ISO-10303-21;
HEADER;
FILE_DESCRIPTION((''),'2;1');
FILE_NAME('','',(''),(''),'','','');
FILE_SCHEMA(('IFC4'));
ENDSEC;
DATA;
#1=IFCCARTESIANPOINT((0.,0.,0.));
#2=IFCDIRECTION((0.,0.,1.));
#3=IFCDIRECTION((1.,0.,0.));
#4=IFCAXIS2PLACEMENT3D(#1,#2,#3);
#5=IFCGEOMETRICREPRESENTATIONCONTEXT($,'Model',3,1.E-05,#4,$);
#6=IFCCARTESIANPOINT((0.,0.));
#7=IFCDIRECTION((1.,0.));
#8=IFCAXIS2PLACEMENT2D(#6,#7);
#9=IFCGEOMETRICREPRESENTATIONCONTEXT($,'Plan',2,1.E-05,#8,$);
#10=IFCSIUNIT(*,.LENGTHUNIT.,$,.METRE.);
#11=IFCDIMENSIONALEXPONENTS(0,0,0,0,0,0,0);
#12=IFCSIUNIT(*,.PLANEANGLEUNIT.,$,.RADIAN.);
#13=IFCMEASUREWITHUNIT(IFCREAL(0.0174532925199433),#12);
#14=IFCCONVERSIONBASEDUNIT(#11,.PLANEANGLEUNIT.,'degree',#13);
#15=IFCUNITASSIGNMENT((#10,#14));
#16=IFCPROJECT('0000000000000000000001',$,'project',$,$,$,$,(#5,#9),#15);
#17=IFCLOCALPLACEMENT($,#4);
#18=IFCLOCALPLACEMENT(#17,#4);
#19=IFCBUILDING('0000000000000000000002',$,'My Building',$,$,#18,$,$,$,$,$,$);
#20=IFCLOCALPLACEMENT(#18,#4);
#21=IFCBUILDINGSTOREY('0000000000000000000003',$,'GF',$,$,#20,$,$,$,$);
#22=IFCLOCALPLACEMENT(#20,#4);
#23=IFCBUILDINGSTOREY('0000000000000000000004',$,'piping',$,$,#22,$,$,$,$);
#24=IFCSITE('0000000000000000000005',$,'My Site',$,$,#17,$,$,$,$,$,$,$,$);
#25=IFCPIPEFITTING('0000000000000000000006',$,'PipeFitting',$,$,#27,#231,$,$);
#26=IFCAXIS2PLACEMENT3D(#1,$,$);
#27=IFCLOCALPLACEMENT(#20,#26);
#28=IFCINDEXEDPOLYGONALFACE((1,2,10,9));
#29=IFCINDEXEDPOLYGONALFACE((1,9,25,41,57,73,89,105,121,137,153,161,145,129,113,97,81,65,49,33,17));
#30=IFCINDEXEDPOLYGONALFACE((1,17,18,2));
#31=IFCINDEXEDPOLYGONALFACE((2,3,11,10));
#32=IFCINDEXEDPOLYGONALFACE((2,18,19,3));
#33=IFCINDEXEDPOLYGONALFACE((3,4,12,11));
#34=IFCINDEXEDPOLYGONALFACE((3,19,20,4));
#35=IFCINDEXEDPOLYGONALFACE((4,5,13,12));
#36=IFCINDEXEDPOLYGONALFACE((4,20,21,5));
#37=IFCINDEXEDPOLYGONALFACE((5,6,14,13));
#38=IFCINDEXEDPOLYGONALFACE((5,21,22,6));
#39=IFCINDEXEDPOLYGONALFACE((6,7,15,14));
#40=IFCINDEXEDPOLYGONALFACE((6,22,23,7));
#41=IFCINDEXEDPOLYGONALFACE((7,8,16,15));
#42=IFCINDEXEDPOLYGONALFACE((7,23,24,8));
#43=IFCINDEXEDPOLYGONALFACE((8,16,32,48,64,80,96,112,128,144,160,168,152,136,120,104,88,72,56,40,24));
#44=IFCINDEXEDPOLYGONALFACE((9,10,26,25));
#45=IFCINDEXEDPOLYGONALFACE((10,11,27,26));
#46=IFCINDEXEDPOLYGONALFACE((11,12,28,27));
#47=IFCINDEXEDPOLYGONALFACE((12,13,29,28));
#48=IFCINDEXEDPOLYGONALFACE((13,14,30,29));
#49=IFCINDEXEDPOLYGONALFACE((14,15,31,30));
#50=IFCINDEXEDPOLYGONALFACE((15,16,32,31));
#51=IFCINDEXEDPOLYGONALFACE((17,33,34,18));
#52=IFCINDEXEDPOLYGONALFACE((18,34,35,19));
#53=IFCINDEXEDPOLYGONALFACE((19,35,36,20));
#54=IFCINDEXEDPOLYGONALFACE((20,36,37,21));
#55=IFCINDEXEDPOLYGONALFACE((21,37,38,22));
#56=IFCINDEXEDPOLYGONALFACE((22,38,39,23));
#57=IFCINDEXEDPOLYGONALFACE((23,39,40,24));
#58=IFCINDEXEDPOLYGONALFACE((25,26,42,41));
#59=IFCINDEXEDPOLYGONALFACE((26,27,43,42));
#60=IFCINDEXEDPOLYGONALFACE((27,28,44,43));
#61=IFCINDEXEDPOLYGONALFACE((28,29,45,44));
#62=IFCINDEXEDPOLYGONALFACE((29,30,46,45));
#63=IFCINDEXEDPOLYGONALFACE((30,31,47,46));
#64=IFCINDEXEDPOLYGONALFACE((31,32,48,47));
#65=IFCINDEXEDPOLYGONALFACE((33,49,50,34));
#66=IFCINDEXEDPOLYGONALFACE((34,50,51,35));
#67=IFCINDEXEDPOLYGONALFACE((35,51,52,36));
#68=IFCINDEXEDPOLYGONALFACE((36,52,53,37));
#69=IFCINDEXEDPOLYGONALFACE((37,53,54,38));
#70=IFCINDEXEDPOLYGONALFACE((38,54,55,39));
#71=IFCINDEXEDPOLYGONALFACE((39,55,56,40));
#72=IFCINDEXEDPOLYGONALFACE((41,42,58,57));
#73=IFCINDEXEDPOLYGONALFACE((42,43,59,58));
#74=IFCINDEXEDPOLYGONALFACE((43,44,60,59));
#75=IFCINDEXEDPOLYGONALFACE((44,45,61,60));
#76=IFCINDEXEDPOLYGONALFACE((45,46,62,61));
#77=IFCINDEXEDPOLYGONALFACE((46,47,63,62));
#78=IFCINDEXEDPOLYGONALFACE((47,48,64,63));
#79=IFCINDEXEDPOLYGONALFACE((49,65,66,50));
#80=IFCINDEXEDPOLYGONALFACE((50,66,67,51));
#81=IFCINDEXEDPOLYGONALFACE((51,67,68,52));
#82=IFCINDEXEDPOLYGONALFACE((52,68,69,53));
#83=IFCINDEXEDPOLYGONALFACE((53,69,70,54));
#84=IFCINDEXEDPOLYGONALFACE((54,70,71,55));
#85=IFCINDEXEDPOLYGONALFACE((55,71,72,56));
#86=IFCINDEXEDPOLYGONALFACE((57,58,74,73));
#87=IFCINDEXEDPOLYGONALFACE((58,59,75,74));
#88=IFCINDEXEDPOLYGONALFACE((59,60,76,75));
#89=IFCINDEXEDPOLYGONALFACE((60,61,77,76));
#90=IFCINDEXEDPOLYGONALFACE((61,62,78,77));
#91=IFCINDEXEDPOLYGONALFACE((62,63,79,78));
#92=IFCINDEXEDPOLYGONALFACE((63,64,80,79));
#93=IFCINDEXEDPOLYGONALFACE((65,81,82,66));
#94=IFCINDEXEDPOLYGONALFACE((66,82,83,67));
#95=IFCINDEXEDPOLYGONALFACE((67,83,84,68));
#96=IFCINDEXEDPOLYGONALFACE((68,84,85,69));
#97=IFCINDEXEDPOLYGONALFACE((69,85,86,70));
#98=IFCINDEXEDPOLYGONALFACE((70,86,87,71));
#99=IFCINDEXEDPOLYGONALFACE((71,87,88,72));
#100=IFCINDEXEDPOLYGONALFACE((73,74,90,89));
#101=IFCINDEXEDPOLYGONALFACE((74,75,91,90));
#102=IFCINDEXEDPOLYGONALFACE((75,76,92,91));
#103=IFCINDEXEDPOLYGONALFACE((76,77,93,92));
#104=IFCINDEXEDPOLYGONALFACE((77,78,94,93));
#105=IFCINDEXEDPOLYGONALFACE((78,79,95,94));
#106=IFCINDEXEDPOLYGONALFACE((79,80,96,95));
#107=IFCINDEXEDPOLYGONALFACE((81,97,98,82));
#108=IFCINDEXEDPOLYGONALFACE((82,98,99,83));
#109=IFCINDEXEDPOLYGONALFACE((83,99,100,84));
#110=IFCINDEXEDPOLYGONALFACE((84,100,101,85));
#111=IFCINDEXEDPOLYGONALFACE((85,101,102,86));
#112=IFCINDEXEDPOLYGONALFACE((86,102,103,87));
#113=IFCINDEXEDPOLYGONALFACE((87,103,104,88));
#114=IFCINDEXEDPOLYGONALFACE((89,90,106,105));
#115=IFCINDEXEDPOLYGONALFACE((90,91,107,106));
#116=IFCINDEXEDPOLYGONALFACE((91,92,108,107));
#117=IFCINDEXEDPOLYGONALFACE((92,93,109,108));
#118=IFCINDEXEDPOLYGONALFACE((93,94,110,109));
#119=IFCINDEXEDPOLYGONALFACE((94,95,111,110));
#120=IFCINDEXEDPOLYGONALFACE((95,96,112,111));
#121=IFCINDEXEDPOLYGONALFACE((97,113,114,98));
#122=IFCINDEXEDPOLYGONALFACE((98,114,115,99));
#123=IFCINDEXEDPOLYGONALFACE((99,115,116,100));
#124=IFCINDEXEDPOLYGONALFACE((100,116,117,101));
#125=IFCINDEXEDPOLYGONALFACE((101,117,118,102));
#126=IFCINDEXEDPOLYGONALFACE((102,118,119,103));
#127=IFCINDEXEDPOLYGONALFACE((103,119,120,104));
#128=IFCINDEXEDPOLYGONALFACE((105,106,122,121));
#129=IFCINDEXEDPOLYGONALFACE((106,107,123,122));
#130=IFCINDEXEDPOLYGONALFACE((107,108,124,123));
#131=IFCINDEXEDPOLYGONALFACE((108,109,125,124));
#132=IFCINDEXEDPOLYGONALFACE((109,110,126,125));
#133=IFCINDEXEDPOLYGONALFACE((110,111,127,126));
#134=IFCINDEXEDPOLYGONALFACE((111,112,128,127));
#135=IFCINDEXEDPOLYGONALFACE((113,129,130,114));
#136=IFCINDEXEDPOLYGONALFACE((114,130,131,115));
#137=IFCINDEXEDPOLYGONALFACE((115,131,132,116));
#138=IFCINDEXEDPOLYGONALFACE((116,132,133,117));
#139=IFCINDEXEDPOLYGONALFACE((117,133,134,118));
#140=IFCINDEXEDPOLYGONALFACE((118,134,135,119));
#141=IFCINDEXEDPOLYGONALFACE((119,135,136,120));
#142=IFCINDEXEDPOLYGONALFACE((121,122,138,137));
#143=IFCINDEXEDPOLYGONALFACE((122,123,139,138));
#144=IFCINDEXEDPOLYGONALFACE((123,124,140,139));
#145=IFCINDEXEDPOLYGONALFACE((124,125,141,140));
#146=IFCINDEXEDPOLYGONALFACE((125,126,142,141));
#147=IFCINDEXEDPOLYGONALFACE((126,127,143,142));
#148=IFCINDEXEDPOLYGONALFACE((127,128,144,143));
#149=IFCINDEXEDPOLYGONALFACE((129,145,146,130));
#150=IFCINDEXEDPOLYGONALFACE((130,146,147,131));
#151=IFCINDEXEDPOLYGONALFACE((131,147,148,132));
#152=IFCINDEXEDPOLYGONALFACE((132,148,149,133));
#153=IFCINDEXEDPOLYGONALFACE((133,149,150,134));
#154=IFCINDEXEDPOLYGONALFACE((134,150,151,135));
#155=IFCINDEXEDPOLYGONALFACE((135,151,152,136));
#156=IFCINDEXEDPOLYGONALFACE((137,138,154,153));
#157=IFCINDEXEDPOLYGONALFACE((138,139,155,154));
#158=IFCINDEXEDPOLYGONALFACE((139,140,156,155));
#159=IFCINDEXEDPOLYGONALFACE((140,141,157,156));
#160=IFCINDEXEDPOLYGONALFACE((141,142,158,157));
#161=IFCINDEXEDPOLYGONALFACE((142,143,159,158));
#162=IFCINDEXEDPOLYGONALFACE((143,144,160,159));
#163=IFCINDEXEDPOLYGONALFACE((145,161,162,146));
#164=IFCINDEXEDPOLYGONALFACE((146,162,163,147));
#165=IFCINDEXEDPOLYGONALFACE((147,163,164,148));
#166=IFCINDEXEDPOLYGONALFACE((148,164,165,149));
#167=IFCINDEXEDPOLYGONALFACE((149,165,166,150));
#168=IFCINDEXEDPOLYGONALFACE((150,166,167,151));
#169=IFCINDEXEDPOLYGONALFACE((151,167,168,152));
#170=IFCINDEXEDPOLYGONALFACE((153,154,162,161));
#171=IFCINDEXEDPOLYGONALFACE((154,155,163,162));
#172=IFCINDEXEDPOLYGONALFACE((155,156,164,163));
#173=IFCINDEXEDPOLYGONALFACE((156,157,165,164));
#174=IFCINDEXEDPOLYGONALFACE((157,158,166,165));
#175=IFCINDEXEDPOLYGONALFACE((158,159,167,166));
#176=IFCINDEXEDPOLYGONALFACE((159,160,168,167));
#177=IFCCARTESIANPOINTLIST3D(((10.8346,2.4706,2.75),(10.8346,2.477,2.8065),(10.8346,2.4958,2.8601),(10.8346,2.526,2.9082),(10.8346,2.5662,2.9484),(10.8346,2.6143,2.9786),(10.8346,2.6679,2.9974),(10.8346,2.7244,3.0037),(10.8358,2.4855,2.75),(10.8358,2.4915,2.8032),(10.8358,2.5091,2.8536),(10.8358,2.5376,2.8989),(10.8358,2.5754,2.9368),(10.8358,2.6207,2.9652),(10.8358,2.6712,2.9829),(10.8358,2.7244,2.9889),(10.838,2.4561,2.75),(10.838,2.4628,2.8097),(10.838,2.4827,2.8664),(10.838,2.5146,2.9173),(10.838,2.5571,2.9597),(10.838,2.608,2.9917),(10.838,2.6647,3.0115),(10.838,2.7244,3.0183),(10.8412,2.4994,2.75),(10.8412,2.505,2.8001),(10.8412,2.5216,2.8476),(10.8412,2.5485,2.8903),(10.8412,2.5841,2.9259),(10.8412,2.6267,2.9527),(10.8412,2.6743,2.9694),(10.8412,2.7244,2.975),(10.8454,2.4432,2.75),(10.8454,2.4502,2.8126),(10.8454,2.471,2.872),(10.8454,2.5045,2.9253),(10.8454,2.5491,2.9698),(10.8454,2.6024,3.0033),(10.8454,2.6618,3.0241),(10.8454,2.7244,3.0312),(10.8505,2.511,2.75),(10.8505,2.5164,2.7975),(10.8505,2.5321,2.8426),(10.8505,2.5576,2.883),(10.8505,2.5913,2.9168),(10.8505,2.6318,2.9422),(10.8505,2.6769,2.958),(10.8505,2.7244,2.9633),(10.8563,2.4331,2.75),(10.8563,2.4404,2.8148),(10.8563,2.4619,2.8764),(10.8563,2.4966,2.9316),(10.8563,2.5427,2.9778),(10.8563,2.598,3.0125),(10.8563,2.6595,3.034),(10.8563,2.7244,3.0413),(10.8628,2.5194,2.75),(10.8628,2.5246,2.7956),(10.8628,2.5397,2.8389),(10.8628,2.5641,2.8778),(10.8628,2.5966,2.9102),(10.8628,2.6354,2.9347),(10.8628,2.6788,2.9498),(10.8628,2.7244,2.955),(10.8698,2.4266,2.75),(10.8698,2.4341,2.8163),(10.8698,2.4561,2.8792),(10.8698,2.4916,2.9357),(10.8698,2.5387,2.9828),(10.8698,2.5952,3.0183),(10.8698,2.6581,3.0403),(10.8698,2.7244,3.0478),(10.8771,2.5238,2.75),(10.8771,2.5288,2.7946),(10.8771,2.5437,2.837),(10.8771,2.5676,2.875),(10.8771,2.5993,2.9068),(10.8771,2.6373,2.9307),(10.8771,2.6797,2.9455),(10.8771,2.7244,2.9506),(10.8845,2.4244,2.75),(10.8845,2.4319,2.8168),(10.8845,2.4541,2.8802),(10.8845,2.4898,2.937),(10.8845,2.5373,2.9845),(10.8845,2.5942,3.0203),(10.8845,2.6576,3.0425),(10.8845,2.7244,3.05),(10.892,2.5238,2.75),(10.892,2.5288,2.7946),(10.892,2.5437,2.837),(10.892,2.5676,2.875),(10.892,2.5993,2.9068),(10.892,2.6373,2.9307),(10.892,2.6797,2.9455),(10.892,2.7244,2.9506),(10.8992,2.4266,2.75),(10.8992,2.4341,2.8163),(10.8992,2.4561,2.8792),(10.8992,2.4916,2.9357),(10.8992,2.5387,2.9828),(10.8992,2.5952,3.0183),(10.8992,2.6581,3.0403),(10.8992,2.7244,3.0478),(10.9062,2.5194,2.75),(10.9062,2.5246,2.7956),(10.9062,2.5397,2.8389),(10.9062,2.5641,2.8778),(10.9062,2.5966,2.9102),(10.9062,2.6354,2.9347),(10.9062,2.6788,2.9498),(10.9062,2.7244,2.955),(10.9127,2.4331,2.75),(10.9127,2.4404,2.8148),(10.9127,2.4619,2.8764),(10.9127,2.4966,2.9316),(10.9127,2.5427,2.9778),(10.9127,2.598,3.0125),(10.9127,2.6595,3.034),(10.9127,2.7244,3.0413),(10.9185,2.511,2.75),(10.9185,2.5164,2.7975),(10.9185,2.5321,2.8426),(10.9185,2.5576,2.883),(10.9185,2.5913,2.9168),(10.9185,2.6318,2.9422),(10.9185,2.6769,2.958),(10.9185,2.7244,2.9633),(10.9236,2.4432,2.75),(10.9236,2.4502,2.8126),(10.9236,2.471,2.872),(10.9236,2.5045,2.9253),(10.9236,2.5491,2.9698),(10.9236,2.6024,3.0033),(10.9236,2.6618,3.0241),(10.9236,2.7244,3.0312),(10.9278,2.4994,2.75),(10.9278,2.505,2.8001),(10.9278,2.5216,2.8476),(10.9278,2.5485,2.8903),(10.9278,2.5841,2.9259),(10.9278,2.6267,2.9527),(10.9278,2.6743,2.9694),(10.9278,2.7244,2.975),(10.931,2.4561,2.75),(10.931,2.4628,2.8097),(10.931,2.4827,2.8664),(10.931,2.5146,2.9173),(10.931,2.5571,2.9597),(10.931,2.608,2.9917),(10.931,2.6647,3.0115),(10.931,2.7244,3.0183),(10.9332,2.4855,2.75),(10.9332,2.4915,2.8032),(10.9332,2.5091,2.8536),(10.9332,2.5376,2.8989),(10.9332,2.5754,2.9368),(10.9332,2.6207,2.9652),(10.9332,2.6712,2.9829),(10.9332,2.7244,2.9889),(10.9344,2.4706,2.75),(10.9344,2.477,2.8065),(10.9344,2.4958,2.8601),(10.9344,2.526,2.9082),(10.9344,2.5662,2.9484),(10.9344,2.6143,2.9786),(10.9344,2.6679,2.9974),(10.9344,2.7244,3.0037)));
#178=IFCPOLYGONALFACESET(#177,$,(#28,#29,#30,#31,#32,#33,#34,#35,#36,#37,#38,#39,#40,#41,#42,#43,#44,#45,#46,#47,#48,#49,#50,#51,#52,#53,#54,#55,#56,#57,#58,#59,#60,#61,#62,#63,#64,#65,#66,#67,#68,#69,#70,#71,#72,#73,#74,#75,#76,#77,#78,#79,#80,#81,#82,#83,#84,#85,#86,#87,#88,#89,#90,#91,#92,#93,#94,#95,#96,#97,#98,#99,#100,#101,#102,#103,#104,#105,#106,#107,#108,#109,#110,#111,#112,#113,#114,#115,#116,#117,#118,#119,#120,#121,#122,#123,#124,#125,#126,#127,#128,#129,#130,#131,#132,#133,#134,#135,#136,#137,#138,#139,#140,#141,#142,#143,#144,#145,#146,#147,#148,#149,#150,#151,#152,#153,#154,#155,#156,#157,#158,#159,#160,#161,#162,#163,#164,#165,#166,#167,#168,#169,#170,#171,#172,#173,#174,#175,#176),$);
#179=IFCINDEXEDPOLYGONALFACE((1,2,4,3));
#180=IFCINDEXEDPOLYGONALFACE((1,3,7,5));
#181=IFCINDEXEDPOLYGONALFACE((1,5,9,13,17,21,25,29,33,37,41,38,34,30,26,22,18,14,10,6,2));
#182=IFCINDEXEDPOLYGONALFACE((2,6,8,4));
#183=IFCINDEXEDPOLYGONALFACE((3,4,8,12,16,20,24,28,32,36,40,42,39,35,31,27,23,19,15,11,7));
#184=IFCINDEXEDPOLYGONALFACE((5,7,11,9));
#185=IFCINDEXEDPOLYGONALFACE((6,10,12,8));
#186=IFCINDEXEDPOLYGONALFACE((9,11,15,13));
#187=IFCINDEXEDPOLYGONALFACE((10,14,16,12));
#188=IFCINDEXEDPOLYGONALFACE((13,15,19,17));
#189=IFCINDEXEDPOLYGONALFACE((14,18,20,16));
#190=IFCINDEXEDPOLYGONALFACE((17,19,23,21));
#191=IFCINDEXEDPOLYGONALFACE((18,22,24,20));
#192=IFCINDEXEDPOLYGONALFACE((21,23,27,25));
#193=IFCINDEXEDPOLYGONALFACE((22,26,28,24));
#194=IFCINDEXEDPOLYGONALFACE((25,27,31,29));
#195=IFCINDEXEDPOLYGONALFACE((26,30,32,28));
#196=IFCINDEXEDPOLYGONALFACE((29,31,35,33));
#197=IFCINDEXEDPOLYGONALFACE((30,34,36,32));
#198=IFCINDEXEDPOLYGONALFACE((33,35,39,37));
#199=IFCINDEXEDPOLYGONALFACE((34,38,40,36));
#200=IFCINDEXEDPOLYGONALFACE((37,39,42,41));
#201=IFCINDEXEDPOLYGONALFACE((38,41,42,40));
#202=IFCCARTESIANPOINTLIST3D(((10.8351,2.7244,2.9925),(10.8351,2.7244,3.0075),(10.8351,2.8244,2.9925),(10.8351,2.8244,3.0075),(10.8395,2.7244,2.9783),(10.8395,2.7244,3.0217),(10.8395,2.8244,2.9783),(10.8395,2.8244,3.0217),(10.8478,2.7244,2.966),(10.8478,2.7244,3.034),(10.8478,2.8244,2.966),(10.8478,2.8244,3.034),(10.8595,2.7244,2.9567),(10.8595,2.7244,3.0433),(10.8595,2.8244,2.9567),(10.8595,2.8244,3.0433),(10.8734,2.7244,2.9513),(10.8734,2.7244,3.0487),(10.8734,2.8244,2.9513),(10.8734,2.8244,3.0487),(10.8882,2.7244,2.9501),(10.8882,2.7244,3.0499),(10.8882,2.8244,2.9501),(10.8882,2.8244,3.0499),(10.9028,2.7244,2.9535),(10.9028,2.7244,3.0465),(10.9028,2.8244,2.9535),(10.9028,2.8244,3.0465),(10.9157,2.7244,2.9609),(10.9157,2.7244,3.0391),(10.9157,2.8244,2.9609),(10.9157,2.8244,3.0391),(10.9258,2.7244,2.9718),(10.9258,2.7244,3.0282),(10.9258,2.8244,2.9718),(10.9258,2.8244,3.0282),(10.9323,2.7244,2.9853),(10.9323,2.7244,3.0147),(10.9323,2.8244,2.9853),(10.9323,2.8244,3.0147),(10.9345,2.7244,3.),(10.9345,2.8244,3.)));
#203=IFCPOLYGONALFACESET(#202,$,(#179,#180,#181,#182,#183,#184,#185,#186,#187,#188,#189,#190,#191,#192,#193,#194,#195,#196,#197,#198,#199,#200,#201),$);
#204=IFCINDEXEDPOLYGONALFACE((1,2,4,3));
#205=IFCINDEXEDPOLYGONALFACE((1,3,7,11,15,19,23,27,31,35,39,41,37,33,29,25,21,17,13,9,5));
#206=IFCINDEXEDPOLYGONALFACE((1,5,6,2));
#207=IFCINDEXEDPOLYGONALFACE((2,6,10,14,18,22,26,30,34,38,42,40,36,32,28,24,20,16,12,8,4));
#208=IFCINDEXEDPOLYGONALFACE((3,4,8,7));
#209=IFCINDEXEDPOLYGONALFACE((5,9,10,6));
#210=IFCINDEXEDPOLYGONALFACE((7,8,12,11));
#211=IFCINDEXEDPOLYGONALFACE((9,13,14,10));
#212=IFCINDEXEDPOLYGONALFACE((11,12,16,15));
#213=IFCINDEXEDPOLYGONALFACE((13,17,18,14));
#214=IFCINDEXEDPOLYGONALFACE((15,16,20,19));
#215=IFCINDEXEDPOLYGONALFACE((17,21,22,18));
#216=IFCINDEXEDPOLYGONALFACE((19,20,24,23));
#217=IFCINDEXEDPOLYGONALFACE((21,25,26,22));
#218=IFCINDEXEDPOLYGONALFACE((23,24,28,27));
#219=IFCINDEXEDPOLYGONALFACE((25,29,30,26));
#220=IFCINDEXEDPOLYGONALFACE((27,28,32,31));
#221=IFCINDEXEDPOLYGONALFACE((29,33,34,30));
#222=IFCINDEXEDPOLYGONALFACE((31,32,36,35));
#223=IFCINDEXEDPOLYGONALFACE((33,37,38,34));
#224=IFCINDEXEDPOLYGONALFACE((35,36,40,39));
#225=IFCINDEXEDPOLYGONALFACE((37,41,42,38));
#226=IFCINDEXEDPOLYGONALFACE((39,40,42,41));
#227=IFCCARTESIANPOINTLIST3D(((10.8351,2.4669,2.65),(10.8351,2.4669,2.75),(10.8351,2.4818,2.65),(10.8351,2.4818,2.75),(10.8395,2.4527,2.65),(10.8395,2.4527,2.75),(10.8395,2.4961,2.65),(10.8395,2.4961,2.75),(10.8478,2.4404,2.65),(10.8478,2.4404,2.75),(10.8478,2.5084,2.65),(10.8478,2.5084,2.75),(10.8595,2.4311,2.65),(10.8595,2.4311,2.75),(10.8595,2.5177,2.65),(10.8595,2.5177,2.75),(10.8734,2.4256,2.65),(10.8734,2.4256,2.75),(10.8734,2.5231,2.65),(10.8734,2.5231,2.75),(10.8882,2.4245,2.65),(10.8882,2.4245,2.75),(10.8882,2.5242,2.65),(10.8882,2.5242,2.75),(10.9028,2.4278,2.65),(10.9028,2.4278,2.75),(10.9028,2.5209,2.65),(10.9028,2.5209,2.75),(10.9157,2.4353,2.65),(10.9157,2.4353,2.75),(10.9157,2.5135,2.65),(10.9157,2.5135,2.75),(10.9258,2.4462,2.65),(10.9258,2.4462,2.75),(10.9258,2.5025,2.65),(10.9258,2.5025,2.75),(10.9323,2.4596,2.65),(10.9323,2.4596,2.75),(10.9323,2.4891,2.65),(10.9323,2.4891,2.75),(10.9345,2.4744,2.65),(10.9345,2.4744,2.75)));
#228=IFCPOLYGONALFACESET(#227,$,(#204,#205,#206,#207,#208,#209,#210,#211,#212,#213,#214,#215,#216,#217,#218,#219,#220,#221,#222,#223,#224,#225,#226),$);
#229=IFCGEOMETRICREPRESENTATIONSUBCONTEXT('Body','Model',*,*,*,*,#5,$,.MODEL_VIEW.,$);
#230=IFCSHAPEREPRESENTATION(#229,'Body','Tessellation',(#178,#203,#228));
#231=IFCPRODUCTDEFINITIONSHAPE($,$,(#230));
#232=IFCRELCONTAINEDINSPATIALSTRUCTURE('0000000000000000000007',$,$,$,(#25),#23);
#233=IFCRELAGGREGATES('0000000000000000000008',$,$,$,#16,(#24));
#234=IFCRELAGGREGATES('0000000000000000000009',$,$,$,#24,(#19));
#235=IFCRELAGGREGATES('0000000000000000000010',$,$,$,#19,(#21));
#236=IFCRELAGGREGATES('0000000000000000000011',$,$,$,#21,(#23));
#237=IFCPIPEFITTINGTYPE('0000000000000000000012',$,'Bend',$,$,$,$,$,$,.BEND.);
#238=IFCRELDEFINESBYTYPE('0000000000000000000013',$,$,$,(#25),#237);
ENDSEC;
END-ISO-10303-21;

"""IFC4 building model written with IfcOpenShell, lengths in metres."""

from ifc_helpers import new_model, entity, si_unit, converted_unit, frame, origin_with_axes, origin_2d_with_axis, place, context, subcontext, project, spatial, circle, extrude, source, transform, mapped, type_object, type_shapes, element, save


model = new_model("IFC4")

# Units and contexts
model_context = context("Model", 3, precision=1e-05, world=origin_with_axes())
plan_context = context("Plan", 2, precision=1e-05, world=origin_2d_with_axis())
body_context = subcontext(model_context, "Body", "Model", "MODEL_VIEW")
ifc_project = project(units=[si_unit("LENGTHUNIT", "METRE"), converted_unit("PLANEANGLEUNIT", "degree", entity("IfcReal", 0.0174532925199433), si_unit("PLANEANGLEUNIT", "RADIAN"), dimensions=[0, 0, 0, 0, 0, 0, 0])], contexts=[model_context, plan_context])

# Site, building, storeys
site_placement = place(None, origin_with_axes())
site = spatial("IfcSite", under=ifc_project, at=site_placement, Name="My Site")
building_placement = place(site_placement, origin_with_axes())
building = spatial("IfcBuilding", under=site, at=building_placement, Name="My Building")
storey_1_placement = place(building_placement, origin_with_axes())
storey_1 = spatial("IfcBuildingStorey", under=building, at=storey_1_placement, Name="GF")
storey_2_placement = place(storey_1_placement, origin_with_axes())
storey_2 = spatial("IfcBuildingStorey", under=storey_1, at=storey_2_placement, Name="piping")

# Pipe fitting
pipe_fitting_type = type_object("IfcPipeFittingType", Name="Bend", PredefinedType="BEND")
shared_shape = source(origin_with_axes(), body_context, "Body", "SolidModel", [
    entity("IfcSweptDiskSolid", entity("IfcIndexedPolyCurve", entity("IfcCartesianPointList3D", [[0.0, 0.0, 0.1], [0.0, -0.0732, 0.2768], [0.0, -0.25, 0.35]]), [entity("IfcArcIndex", [1, 2, 3])]), 0.05),
    extrude(circle(Radius=0.05), origin_with_axes(), (0.0, 0.0, 1.0), 0.1),
    extrude(circle(Radius=0.05), frame((0.0, -0.25, 0.35), z_axis=(0.0, -1.0, 0.0), x_axis=(1.0, 0.0, 0.0)), (0.0, 0.0, 1.0), 0.1),
])
type_shapes(pipe_fitting_type, [shared_shape])
for number, where, z_axis, x_axis, name in (
    (1, (10.8845, 2.8244, 3.0), (0.0, -1.0, 0.0), (1.0, 0.0, 0.0), "PipeFitting"),
):
    element("IfcPipeFitting", number, at=place(storey_2_placement, frame(where, z_axis=z_axis, x_axis=x_axis)), inside=storey_2, type_object=pipe_fitting_type, Name=name, context=body_context, shape_type="MappedRepresentation", body=[
        mapped(shared_shape, transform((0.0, 0.0, 0.0), x_axis=(1.0, 0.0, 0.0), y_axis=(0.0, 1.0, 0.0), z_axis=(0.0, 0.0, 1.0), scale=1.0)),
    ])

save(model, "model.ifc")
